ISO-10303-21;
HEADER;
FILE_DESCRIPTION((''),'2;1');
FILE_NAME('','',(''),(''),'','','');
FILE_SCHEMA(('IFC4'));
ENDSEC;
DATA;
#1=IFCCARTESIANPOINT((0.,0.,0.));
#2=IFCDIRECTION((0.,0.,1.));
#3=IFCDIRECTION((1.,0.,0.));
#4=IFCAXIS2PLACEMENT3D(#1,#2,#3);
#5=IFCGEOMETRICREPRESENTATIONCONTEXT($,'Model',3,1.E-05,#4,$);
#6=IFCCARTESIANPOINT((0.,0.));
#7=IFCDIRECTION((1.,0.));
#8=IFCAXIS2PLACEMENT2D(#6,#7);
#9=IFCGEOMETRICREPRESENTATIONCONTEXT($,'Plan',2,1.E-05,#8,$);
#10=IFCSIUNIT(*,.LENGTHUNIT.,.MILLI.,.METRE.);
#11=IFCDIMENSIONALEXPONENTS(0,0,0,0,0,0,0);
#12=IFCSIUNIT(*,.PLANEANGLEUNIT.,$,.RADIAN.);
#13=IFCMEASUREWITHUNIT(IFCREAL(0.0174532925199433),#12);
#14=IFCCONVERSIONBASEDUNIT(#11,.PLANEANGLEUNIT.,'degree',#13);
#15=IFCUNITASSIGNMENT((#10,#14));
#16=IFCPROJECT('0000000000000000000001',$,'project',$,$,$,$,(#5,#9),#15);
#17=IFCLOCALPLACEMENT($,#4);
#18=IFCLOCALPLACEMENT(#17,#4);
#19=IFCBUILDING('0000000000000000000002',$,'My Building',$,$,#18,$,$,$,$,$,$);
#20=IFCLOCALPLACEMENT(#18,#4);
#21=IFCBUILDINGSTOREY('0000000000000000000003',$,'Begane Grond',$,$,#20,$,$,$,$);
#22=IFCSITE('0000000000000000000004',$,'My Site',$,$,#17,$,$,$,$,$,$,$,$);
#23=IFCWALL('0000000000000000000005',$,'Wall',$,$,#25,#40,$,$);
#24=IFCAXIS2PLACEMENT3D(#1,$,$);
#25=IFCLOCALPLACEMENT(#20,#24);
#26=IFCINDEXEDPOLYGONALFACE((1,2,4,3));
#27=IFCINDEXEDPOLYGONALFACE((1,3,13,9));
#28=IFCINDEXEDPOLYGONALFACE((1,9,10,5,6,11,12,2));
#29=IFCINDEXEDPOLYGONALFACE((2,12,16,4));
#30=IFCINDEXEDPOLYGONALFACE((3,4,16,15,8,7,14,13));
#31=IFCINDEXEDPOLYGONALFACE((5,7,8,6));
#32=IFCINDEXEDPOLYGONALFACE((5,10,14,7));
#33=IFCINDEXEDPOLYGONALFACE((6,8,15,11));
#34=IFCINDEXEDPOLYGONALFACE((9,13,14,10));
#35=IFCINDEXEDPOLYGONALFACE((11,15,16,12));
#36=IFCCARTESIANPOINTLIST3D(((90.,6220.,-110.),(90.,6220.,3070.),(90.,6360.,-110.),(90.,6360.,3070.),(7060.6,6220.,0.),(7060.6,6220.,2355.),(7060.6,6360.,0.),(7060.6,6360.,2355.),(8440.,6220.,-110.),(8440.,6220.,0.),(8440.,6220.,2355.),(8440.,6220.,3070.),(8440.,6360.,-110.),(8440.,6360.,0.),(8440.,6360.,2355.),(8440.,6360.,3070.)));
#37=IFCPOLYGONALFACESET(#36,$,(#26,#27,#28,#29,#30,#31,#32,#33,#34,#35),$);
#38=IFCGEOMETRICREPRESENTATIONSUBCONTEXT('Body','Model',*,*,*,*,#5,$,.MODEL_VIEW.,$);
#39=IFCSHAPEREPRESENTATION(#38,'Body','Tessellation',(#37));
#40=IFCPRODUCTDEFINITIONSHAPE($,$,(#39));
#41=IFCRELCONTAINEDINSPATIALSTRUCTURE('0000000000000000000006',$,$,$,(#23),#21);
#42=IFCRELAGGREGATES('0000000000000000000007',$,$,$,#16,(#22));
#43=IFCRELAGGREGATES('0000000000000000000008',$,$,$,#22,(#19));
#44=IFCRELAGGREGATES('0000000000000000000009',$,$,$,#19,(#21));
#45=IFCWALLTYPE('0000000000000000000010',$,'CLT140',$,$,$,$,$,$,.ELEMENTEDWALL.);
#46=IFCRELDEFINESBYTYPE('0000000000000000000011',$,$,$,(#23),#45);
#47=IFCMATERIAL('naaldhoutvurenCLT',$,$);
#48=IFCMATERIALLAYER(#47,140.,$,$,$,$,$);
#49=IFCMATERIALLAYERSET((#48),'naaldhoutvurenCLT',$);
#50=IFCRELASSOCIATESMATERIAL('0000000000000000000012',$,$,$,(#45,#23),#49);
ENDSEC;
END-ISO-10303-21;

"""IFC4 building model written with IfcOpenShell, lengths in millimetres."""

from ifc_helpers import new_model, entity, si_unit, converted_unit, frame, origin_with_axes, origin_2d_with_axis, place, context, subcontext, project, spatial, line, indexed_curve, outline, extrude, source, transform, mapped, material, layer, layer_set, layer_usage, type_object, element, save


model = new_model("IFC4")

# Units and contexts
model_context = context("Model", 3, precision=1e-05, world=origin_with_axes())
plan_context = context("Plan", 2, precision=1e-05, world=origin_2d_with_axis())
body_context = subcontext(model_context, "Body", "Model", "MODEL_VIEW")
ifc_project = project(units=[si_unit("LENGTHUNIT", "METRE", prefix="MILLI"), converted_unit("PLANEANGLEUNIT", "degree", entity("IfcReal", 0.0174532925199433), si_unit("PLANEANGLEUNIT", "RADIAN"), dimensions=[0, 0, 0, 0, 0, 0, 0])], contexts=[model_context, plan_context])

# Site, building, storey
site_placement = place(None, origin_with_axes())
site = spatial("IfcSite", under=ifc_project, at=site_placement, Name="My Site")
building_placement = place(site_placement, origin_with_axes())
building = spatial("IfcBuilding", under=site, at=building_placement, Name="My Building")
storey_placement = place(building_placement, origin_with_axes())
storey = spatial("IfcBuildingStorey", under=building, at=storey_placement, Name="Begane Grond")

# Wall, opening
ifc_material_1 = material(Name="naaldhoutvurenCLT")
ifc_layer_1 = layer(ifc_material_1, 140.0)
ifc_layer_set_1 = layer_set([ifc_layer_1], Name="naaldhoutvurenCLT")
ifc_layer_usage_1 = layer_usage(ifc_layer_set_1, "AXIS2", "POSITIVE", 0.0)
wall_type_1 = type_object("IfcWallType", Name="CLT140", PredefinedType="ELEMENTEDWALL", material=ifc_layer_set_1)
wall_1_placement = place(storey_placement, frame((90.0, 6220.0, -110.0), z_axis=(0.0, 0.0, 1.0), x_axis=(1.0, -0.000001, 0.0)))
wall_1 = element("IfcWall", 1, at=wall_1_placement, inside=storey, type_object=wall_type_1, material=ifc_layer_usage_1, Name="Wall", context=body_context, shape_type="SweptSolid", body=[
    extrude(outline(indexed_curve([(0.0, 0.0), (0.0, 140.0), (8350.0, 140.0), (8350.0, 0.0), (0.0, 0.0)], self_intersect=False)), origin_with_axes(), (0.0, 0.0, 1.0), 3180.0),
])
shared_shape_1 = source(origin_with_axes(), body_context, "Body", "SweptSolid", [
    extrude(outline(indexed_curve([(0.0, 0.0), (1379.4, 0.0), (1379.4, 2355.0), (0.0, 2355.0)], segments=[line(1, 2, 3, 4, 1)])), frame((0.0, -600.0, 0.0), z_axis=(0.0, -1.0, 0.0), x_axis=(1.0, 0.0, 0.0)), (0.0, 0.0, -1.0), 1200.0),
])
opening_1_placement = place(wall_1_placement, frame((6970.6, 13.0, 110.0), z_axis=(0.0, 0.0, 1.0), x_axis=(1.0, 0.0, 0.0)))
element("IfcOpeningElement", 2, at=opening_1_placement, cuts=wall_1, PredefinedType="OPENING", context=body_context, shape_type="MappedRepresentation", body=[
    mapped(shared_shape_1, transform((0.0, 0.0, 0.0), x_axis=(1.0, 0.0, 0.0), y_axis=(0.0, 1.0, 0.0), z_axis=(0.0, 0.0, 1.0), scale=1.0)),
])

save(model, "model.ifc")
